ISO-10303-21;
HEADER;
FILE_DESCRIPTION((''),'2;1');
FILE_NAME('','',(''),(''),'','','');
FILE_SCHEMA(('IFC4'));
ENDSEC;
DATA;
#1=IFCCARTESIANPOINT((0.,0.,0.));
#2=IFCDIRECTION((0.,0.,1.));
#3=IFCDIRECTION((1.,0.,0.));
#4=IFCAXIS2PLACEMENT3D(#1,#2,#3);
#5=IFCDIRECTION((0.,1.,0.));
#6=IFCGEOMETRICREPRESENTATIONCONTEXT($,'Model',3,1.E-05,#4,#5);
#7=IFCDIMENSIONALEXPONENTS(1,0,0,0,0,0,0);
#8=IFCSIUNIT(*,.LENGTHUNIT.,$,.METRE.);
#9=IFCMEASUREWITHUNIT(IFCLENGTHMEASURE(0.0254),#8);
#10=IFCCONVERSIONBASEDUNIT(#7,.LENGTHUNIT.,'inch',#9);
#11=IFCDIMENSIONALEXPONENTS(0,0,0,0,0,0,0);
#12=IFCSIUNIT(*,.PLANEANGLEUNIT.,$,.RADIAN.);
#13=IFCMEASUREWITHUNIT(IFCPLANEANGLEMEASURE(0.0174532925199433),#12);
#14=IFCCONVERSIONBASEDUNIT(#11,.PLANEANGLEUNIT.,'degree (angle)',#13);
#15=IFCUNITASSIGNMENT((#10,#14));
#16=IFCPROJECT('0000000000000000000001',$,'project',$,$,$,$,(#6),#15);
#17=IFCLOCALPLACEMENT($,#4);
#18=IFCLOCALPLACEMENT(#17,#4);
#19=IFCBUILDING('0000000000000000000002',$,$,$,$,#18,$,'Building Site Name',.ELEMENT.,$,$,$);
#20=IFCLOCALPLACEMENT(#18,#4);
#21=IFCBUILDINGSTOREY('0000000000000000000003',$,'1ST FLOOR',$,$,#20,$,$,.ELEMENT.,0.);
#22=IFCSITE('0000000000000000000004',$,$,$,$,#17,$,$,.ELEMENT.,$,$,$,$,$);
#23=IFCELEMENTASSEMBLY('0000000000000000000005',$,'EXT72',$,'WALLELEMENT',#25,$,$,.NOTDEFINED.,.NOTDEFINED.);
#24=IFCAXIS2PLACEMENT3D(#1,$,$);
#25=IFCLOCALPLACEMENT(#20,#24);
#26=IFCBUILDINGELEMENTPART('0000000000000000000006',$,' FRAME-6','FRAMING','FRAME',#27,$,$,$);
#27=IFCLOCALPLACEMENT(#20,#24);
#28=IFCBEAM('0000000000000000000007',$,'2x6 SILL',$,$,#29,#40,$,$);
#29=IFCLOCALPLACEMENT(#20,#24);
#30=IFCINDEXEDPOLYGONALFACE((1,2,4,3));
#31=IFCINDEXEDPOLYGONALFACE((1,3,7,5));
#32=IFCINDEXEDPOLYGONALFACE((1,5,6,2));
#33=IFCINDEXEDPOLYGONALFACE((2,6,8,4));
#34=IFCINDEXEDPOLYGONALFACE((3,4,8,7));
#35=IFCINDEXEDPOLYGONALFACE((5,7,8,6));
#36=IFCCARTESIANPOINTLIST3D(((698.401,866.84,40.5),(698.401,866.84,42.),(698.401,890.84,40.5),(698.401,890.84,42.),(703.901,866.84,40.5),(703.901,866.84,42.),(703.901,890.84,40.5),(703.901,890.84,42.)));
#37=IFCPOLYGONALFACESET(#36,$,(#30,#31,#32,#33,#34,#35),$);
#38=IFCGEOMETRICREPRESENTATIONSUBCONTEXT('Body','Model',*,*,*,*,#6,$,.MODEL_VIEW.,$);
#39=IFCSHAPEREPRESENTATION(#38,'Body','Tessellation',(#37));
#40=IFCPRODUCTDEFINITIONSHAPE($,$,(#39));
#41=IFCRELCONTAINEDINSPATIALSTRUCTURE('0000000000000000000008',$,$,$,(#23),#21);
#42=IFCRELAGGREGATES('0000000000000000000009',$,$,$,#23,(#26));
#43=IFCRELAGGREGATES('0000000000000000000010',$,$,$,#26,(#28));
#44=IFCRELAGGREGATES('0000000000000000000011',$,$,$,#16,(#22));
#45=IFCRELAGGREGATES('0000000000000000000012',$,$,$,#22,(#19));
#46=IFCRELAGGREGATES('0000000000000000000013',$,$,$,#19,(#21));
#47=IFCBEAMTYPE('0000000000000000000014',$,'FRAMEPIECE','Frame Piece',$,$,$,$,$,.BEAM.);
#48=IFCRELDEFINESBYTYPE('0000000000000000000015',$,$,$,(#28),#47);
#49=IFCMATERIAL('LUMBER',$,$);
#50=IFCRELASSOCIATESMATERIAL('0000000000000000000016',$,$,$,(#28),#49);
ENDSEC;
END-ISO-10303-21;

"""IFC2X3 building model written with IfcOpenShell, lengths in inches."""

from ifc_helpers import new_model, entity, si_unit, converted_unit, direction, frame, frame_2d, origin_with_axes, place, context, subcontext, project, spatial, rectangle, extrude, material, type_object, element, aggregate, save


model = new_model("IFC2X3")

# Units and contexts
model_context = context("Model", 3, precision=1e-05, world=origin_with_axes(), true_north=direction((0.0, 1.0, 0.0)))
body_context = subcontext(model_context, "Body", "Model", "MODEL_VIEW")
ifc_project = project(units=[converted_unit("LENGTHUNIT", "inch", entity("IfcLengthMeasure", 0.0254), si_unit("LENGTHUNIT", "METRE"), dimensions=[1, 0, 0, 0, 0, 0, 0]), converted_unit("PLANEANGLEUNIT", "degree (angle)", entity("IfcPlaneAngleMeasure", 0.0174532925199433), si_unit("PLANEANGLEUNIT", "RADIAN"), dimensions=[0, 0, 0, 0, 0, 0, 0])], contexts=[model_context])

# Site, building, storey
site_placement = place(None, origin_with_axes())
site = spatial("IfcSite", under=ifc_project, at=site_placement, CompositionType="ELEMENT")
building_placement = place(site_placement, origin_with_axes())
building = spatial("IfcBuilding", under=site, at=building_placement, LongName="Building Site Name", CompositionType="ELEMENT")
storey_placement = place(building_placement, origin_with_axes())
storey = spatial("IfcBuildingStorey", under=building, at=storey_placement, Name="1ST FLOOR", CompositionType="ELEMENT", Elevation=0.0)

# Element assembly, building element part
ifc_material_1 = material(Name="LUMBER")
beam_type = type_object("IfcBeamType", Name="FRAMEPIECE", Description="Frame Piece", PredefinedType="BEAM")
assembly_1_placement = place(storey_placement, origin_with_axes())
assembly_1 = element("IfcElementAssembly", 1, at=assembly_1_placement, inside=storey, Name="EXT72", ObjectType="WALLELEMENT", AssemblyPlace="NOTDEFINED", PredefinedType="NOTDEFINED")
building_element_part_1 = element("IfcBuildingElementPart", 2, Name=" FRAME-6", Description="FRAMING", ObjectType="FRAME")
aggregate(assembly_1, [building_element_part_1])

# Beam
beam_1_placement = place(assembly_1_placement, frame((701.151, 866.84, 41.25), z_axis=(0.0, 1.0, 0.0), x_axis=(0.0, 0.0, -1.0)))
beam_1 = element("IfcBeam", 3, at=beam_1_placement, type_object=beam_type, material=ifc_material_1, Name="2x6 SILL", context=body_context, shape_type="SweptSolid", body=[
    extrude(rectangle(XDim=1.5, YDim=5.5, at=frame_2d((0.0, 0.0), x_axis=(-1.0, 0.0))), frame((0.0, 0.0, 0.0), z_axis=(0.0, 0.0, 1.0), x_axis=(1.0, 0.0, 0.0)), (0.0, 0.0, 1.0), 24.0),
])
aggregate(building_element_part_1, [beam_1])

save(model, "model.ifc")
